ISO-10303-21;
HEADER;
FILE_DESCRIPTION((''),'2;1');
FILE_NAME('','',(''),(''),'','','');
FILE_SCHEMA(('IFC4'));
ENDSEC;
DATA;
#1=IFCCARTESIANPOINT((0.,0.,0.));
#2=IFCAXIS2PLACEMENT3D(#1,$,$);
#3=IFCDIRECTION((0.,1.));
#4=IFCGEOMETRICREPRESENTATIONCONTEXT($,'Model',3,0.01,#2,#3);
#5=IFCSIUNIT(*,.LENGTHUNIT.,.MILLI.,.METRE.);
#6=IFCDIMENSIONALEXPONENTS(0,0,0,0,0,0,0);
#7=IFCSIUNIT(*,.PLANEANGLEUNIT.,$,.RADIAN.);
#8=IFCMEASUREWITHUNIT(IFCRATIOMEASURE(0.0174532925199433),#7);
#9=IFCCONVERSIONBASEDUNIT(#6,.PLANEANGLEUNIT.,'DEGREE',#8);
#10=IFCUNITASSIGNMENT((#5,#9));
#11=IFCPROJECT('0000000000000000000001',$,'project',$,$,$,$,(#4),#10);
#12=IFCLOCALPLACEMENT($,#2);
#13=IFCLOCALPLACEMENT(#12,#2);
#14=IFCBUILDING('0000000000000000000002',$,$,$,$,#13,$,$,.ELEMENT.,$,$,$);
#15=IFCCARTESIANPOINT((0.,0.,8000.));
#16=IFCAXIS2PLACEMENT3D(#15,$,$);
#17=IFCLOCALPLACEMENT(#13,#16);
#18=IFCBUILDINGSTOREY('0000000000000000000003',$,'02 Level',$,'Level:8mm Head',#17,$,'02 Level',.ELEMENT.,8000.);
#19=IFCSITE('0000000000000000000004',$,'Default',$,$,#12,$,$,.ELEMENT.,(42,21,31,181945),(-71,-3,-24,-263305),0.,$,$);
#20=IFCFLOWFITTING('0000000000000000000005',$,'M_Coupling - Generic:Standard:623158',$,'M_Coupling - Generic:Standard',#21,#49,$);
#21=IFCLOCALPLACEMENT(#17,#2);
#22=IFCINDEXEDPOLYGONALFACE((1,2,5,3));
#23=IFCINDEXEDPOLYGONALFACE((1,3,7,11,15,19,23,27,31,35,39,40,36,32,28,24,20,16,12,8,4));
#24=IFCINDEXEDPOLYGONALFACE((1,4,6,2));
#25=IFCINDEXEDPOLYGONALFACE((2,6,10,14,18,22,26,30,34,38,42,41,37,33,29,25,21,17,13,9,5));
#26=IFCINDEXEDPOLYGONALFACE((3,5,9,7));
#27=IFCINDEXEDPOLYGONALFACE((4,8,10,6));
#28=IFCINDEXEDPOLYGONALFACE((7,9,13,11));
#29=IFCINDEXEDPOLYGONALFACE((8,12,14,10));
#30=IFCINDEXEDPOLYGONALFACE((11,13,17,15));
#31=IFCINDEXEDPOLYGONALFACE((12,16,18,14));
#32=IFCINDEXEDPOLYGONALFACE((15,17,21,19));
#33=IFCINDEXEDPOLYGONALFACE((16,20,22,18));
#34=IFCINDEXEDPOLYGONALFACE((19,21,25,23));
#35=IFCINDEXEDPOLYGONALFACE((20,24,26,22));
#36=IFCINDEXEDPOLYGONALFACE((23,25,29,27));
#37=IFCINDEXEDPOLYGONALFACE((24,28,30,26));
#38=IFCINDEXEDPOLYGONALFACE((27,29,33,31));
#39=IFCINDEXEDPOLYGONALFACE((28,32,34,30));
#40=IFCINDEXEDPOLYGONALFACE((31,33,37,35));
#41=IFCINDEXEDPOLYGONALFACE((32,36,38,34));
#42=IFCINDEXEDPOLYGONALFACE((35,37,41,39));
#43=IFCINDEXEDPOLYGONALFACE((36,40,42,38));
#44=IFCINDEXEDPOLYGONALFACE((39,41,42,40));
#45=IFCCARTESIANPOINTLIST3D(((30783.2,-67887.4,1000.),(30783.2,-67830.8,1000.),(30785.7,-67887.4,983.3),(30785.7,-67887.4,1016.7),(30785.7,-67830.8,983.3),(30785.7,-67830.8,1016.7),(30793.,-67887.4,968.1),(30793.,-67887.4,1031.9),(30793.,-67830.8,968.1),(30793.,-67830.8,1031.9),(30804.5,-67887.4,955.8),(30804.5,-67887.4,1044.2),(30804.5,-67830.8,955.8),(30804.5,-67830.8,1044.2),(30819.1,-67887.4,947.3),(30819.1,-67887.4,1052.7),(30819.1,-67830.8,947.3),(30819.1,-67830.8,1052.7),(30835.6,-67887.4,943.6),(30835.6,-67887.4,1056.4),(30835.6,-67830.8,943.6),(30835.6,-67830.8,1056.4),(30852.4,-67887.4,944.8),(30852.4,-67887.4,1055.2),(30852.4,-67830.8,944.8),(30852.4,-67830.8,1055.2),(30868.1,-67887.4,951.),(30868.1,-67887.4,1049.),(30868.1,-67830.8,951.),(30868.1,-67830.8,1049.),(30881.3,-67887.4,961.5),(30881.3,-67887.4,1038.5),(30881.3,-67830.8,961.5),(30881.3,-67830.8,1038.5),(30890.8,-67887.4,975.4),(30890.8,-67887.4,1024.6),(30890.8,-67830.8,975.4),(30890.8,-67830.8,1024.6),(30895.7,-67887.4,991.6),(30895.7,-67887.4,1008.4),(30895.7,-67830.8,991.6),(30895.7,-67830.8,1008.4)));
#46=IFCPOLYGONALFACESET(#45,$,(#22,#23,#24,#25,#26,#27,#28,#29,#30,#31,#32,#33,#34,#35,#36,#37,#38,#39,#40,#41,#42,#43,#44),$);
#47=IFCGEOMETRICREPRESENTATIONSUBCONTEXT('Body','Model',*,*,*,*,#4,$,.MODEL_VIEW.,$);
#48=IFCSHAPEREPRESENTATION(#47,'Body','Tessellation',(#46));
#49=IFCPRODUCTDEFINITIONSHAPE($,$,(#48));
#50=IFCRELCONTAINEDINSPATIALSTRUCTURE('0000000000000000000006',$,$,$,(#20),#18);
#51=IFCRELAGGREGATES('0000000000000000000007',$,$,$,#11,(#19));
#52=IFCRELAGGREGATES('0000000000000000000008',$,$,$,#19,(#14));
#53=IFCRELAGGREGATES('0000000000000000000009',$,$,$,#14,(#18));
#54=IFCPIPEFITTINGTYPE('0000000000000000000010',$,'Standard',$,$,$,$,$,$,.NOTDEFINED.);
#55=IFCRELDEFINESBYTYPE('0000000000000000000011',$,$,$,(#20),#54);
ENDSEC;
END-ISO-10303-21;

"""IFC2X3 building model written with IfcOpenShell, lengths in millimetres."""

from ifc_helpers import new_model, entity, si_unit, converted_unit, direction, frame, frame_2d, origin, place, context, subcontext, project, spatial, circle, extrude, source, transform, mapped, type_object, type_shapes, element, save


model = new_model("IFC2X3")

# Units and contexts
model_context = context("Model", 3, precision=0.01, world=origin(), true_north=direction((0.0, 1.0)))
body_context = subcontext(model_context, "Body", "Model", "MODEL_VIEW")
ifc_project = project(units=[si_unit("LENGTHUNIT", "METRE", prefix="MILLI"), converted_unit("PLANEANGLEUNIT", "DEGREE", entity("IfcRatioMeasure", 0.0174532925199433), si_unit("PLANEANGLEUNIT", "RADIAN"), dimensions=[0, 0, 0, 0, 0, 0, 0])], contexts=[model_context])

# Site, building, storey
site_placement = place(None, origin())
site = spatial("IfcSite", under=ifc_project, at=site_placement, Name="Default", CompositionType="ELEMENT", RefLatitude=(42, 21, 31, 181945), RefLongitude=(-71, -3, -24, -263305), RefElevation=0.0)
building_placement = place(site_placement, origin())
building = spatial("IfcBuilding", under=site, at=building_placement, CompositionType="ELEMENT")
storey_placement = place(building_placement, frame((0.0, 0.0, 8000.0)))
storey = spatial("IfcBuildingStorey", under=building, at=storey_placement, Name="02 Level", ObjectType="Level:8mm Head", LongName="02 Level", CompositionType="ELEMENT", Elevation=8000.0)

# Flow fitting
pipe_fitting_type = type_object("IfcPipeFittingType", Name="Standard", PredefinedType="NOTDEFINED")
shared_shape = source(origin(), body_context, "Body", "SweptSolid", [
    extrude(circle(Radius=56.6, at=frame_2d((0.0, 0.0), x_axis=(1.0, 0.0))), frame((-28.3, 0.0, 0.0), z_axis=(1.0, 0.0, 0.0), x_axis=(0.0, 1.0, 0.0)), (0.0, 0.0, 1.0), 56.6),
])
type_shapes(pipe_fitting_type, [shared_shape])
flow_fitting_placement = place(storey_placement, frame((30839.8, -67859.1, 1000.0), z_axis=(0.0, 0.0, 1.0), x_axis=(0.0, 1.0, 0.0)))
element("IfcFlowFitting", 1, at=flow_fitting_placement, inside=storey, type_object=pipe_fitting_type, Name="M_Coupling - Generic:Standard:623158", ObjectType="M_Coupling - Generic:Standard", context=body_context, shape_type="MappedRepresentation", body=[
    mapped(shared_shape, transform((0.0, 0.0, 0.0), scale=1.0)),
])

save(model, "model.ifc")
